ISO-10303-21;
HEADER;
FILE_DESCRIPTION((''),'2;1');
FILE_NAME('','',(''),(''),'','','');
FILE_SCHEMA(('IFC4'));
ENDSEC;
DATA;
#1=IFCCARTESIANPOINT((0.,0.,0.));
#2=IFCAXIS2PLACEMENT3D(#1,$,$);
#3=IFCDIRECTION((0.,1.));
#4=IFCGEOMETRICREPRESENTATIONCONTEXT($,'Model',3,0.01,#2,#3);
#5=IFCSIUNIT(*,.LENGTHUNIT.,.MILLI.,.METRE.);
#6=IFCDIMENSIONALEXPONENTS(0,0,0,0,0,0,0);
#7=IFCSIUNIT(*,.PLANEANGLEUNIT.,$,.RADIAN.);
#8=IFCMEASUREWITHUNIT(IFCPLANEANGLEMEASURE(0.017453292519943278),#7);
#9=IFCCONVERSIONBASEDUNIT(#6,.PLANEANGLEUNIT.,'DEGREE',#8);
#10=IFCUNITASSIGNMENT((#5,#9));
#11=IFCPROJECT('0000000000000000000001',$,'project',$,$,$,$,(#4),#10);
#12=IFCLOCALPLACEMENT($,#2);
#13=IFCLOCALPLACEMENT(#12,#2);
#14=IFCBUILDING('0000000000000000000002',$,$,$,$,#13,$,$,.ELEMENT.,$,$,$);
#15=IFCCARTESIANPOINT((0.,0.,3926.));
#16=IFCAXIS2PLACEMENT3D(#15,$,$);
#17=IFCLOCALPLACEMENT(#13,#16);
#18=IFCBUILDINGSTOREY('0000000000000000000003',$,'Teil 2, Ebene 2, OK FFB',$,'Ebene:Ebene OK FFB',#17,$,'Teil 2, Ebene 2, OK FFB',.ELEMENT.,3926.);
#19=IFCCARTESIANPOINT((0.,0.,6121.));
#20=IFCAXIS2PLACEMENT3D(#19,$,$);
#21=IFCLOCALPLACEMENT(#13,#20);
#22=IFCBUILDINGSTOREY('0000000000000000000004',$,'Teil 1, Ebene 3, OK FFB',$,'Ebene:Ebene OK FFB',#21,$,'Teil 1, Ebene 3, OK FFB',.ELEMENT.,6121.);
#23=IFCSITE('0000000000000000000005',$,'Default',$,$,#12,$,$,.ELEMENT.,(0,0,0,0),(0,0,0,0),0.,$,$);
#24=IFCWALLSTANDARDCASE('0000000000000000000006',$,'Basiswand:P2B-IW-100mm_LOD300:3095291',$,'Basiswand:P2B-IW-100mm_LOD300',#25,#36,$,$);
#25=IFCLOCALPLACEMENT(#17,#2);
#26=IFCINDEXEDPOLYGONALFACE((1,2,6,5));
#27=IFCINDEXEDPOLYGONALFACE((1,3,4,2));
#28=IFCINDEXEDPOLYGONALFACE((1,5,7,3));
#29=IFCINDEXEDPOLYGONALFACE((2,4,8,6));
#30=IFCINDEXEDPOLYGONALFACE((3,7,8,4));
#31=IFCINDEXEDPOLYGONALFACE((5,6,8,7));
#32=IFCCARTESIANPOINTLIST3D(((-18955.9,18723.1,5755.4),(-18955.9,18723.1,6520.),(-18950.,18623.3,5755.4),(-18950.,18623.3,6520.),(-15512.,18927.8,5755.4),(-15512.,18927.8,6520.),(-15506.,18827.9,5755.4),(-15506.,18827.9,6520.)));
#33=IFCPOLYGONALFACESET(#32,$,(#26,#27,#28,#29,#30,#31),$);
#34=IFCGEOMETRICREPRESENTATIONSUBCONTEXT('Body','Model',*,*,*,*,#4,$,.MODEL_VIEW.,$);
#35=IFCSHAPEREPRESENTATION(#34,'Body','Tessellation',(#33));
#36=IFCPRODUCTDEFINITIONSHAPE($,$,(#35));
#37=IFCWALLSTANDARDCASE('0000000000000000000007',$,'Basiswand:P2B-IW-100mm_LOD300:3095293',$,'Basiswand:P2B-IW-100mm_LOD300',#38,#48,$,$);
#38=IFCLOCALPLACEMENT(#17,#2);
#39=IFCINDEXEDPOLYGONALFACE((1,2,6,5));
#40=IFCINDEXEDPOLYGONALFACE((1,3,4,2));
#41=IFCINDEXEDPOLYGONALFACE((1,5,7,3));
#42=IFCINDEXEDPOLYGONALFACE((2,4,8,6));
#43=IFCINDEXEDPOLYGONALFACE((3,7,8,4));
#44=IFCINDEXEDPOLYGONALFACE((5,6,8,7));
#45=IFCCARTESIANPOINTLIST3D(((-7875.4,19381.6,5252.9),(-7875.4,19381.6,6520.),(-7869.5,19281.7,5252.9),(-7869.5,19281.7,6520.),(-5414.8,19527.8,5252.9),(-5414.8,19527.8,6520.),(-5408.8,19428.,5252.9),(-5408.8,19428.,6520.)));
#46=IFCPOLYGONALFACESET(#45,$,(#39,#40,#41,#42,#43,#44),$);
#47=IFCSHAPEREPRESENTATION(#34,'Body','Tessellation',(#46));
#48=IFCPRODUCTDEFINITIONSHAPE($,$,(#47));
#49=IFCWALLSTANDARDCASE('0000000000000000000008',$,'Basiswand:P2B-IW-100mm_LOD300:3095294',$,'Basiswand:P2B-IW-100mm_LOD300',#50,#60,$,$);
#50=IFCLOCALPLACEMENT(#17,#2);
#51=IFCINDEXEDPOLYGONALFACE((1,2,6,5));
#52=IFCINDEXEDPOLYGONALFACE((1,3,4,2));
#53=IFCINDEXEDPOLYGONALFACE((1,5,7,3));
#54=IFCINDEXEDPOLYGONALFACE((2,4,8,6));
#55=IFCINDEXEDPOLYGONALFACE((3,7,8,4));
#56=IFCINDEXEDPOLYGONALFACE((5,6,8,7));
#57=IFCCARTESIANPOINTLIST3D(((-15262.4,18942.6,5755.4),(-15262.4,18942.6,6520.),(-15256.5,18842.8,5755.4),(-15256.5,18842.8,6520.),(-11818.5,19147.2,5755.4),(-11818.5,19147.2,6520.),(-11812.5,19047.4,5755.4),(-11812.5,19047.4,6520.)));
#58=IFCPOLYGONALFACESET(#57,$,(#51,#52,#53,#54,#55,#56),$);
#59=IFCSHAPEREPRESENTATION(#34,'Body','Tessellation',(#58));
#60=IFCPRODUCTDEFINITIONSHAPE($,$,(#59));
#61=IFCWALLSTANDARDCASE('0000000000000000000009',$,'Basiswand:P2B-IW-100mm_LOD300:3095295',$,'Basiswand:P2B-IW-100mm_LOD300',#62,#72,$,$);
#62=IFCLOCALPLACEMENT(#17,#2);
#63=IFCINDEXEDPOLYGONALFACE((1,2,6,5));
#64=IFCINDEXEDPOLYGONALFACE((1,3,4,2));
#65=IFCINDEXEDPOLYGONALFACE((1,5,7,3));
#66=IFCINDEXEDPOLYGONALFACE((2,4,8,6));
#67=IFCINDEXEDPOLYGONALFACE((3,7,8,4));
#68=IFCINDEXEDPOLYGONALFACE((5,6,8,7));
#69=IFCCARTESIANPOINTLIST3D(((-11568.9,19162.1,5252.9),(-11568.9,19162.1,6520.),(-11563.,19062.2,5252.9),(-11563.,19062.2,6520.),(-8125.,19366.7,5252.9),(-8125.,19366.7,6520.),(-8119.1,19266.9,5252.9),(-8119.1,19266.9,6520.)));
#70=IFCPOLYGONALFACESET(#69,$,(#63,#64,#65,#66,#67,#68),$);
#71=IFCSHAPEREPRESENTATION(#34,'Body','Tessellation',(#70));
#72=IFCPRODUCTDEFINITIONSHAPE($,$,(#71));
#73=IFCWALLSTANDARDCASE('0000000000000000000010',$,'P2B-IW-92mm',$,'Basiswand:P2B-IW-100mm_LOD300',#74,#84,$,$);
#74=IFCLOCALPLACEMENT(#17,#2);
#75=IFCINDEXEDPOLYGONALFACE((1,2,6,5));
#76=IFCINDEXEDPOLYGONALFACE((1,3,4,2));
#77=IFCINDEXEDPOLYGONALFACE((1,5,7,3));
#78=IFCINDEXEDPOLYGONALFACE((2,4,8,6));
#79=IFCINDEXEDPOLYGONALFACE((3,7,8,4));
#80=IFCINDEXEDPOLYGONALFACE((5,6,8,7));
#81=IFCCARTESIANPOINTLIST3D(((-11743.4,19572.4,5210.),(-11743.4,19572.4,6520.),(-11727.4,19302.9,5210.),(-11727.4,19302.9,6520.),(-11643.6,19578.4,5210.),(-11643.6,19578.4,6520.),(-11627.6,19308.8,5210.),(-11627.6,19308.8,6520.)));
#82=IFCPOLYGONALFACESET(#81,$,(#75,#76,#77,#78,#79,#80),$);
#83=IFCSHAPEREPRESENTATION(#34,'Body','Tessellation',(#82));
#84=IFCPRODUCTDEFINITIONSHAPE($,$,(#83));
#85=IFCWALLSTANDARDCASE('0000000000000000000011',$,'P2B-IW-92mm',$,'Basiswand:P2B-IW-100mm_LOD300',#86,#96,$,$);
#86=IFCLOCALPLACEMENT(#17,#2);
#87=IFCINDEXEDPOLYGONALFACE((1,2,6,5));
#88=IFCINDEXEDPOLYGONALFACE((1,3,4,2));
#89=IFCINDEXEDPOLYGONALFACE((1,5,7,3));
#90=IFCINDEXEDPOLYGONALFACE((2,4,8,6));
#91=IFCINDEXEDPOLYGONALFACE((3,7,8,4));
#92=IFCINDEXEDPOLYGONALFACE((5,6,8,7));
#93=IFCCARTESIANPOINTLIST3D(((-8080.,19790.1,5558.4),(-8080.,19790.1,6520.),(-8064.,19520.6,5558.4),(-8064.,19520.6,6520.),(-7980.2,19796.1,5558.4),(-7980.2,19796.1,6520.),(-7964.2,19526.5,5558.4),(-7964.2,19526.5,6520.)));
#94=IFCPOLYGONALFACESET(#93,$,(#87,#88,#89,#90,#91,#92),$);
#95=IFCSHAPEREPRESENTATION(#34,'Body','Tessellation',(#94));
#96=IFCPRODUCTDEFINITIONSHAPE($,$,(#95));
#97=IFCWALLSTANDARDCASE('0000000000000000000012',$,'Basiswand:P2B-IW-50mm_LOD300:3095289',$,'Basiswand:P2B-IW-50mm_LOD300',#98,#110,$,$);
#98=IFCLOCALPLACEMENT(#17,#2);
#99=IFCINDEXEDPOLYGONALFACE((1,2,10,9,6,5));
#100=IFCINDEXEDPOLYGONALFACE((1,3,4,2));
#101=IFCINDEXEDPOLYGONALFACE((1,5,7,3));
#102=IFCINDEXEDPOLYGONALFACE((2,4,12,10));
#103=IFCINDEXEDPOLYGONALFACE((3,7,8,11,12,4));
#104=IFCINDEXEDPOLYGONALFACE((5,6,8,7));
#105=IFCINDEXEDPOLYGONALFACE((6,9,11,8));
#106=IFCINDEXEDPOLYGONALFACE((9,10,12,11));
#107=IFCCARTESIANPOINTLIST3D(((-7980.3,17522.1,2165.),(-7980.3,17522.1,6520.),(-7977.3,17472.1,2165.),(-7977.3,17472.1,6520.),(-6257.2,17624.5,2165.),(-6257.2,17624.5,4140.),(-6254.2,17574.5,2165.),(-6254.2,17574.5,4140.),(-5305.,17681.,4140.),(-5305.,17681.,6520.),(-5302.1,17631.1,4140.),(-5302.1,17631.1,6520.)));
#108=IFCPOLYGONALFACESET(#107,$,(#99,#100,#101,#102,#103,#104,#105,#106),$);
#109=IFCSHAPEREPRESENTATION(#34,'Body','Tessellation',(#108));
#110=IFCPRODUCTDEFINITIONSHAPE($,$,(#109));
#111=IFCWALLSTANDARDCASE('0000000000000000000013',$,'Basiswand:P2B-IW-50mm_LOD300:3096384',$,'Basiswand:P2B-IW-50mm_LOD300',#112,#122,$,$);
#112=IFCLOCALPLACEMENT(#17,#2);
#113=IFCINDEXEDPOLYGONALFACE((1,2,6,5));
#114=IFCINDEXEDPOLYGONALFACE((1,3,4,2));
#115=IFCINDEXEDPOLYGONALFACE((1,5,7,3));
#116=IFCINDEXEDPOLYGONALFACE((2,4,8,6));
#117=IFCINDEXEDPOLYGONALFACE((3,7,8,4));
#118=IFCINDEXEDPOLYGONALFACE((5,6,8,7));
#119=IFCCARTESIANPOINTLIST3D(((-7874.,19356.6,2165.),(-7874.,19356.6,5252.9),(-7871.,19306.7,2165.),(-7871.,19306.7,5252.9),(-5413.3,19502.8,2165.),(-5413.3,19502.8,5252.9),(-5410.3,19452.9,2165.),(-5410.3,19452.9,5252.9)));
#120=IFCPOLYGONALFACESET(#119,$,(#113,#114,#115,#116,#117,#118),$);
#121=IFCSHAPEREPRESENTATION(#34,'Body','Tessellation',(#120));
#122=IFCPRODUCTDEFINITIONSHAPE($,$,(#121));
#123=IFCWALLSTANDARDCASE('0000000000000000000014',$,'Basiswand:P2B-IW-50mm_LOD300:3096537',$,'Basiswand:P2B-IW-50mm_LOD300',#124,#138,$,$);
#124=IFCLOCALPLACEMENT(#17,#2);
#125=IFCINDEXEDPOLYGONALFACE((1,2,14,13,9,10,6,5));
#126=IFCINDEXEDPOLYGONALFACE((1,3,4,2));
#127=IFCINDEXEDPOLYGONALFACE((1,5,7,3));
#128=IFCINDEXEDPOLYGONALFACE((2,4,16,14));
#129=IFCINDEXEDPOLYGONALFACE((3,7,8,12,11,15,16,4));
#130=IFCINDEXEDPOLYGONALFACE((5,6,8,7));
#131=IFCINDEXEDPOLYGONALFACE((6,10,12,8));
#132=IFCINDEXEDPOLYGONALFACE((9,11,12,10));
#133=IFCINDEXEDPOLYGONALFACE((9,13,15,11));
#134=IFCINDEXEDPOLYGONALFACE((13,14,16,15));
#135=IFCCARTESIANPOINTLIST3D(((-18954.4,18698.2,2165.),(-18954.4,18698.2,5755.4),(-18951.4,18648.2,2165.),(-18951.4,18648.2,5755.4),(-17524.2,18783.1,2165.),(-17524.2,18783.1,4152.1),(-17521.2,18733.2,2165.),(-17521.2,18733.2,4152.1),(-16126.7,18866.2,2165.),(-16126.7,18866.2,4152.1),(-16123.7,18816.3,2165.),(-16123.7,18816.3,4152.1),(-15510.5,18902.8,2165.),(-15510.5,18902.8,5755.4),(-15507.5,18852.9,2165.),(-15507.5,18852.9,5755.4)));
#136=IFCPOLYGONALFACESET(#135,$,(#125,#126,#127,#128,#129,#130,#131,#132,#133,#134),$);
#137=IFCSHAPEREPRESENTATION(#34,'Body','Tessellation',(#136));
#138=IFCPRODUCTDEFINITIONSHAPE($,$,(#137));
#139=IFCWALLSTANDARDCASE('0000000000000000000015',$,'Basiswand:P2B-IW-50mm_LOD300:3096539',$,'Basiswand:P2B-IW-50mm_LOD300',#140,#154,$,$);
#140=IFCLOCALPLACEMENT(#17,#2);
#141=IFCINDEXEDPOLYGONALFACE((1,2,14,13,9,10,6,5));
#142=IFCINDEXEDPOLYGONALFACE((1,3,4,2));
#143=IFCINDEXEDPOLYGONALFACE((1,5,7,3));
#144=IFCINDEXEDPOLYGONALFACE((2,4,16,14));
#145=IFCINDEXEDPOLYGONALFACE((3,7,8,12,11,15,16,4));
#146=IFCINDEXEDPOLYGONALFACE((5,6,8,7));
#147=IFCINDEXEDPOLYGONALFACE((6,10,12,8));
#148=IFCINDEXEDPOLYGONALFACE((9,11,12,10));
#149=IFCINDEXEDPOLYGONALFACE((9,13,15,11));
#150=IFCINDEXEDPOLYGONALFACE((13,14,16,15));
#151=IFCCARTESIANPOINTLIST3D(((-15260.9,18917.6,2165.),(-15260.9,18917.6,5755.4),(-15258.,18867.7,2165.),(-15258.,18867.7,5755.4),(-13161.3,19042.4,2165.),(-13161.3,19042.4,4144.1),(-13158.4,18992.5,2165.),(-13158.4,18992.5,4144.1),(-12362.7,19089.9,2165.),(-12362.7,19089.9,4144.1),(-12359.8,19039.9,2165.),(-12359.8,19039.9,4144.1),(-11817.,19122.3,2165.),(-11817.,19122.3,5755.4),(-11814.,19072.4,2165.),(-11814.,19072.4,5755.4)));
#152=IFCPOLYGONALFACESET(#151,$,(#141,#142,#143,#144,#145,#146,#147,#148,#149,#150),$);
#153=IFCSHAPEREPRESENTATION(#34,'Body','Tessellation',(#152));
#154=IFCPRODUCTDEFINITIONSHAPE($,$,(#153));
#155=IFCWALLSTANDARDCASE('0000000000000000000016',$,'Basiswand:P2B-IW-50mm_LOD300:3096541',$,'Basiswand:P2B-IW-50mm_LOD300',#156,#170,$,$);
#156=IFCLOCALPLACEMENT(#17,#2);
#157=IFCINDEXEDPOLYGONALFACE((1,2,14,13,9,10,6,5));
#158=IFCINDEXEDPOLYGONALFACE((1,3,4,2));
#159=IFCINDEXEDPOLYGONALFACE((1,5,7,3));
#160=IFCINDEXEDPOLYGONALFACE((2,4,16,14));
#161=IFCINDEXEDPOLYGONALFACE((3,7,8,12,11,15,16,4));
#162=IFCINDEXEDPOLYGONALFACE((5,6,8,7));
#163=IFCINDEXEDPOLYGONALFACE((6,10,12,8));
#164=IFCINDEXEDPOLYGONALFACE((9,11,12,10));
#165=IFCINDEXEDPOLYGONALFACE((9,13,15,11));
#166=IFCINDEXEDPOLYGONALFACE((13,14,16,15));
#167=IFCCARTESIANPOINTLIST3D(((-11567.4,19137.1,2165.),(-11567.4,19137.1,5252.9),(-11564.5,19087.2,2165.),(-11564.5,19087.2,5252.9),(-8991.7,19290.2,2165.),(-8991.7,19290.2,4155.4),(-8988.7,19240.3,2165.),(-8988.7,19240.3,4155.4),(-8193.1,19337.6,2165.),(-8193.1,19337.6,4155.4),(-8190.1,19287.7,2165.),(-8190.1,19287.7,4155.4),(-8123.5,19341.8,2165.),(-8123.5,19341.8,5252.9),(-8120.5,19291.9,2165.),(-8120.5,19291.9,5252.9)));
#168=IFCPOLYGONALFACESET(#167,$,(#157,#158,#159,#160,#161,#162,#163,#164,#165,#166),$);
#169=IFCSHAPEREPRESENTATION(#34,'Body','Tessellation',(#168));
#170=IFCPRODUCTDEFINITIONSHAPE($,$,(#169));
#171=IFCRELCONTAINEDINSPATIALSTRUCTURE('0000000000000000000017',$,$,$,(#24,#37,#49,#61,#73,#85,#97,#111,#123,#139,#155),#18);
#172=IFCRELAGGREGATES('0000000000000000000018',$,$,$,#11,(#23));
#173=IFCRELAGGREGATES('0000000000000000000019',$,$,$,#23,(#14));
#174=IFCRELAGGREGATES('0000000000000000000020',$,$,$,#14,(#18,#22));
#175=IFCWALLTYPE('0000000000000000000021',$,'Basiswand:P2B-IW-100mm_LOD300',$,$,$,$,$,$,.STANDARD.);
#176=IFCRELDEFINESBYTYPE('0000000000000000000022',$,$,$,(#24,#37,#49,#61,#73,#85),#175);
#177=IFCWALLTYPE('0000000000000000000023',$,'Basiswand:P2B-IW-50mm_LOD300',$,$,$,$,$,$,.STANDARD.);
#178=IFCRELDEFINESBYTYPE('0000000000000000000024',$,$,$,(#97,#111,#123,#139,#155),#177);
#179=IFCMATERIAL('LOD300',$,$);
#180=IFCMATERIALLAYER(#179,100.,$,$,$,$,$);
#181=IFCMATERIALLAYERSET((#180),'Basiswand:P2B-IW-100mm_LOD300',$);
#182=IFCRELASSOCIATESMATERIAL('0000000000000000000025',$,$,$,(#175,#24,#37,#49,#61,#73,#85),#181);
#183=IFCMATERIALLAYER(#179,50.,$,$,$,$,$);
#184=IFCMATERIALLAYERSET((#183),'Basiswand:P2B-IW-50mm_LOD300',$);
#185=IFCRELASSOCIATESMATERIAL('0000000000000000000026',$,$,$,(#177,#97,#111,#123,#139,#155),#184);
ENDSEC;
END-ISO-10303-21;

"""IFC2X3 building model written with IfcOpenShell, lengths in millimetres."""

from ifc_helpers import new_model, entity, si_unit, converted_unit, direction, frame, frame_2d, origin, place, context, subcontext, project, spatial, rectangle, extrude, material, layer, layer_set, layer_usage, type_object, element, save


model = new_model("IFC2X3")

# Units and contexts
model_context = context("Model", 3, precision=0.01, world=origin(), true_north=direction((0.0, 1.0)))
body_context = subcontext(model_context, "Body", "Model", "MODEL_VIEW")
ifc_project = project(units=[si_unit("LENGTHUNIT", "METRE", prefix="MILLI"), converted_unit("PLANEANGLEUNIT", "DEGREE", entity("IfcPlaneAngleMeasure", 0.017453292519943278), si_unit("PLANEANGLEUNIT", "RADIAN"), dimensions=[0, 0, 0, 0, 0, 0, 0])], contexts=[model_context])

# Site, building, storey
site_placement = place(None, origin())
site = spatial("IfcSite", under=ifc_project, at=site_placement, Name="Default", CompositionType="ELEMENT", RefLatitude=(0, 0, 0, 0), RefLongitude=(0, 0, 0, 0), RefElevation=0.0)
building_placement = place(site_placement, origin())
building = spatial("IfcBuilding", under=site, at=building_placement, CompositionType="ELEMENT")
storey_1_placement = place(building_placement, frame((0.0, 0.0, 3926.0)))
storey_1 = spatial("IfcBuildingStorey", under=building, at=storey_1_placement, Name="Teil 2, Ebene 2, OK FFB", ObjectType="Ebene:Ebene OK FFB", LongName="Teil 2, Ebene 2, OK FFB", CompositionType="ELEMENT", Elevation=3926.0)

# Shared definitions
storey_2_placement = place(building_placement, frame((0.0, 0.0, 6121.0)))
storey_2 = spatial("IfcBuildingStorey", under=building, at=storey_2_placement, Name="Teil 1, Ebene 3, OK FFB", ObjectType="Ebene:Ebene OK FFB", LongName="Teil 1, Ebene 3, OK FFB", CompositionType="ELEMENT", Elevation=6121.0)

# Walls
ifc_material_1 = material(Name="LOD300")
ifc_layer_1 = layer(ifc_material_1, 100.0)
ifc_layer_set_1 = layer_set([ifc_layer_1], Name="Basiswand:P2B-IW-100mm_LOD300")
ifc_layer_usage_1 = layer_usage(ifc_layer_set_1, "AXIS2", "POSITIVE", -50.0)
wall_type_1 = type_object("IfcWallType", Name="Basiswand:P2B-IW-100mm_LOD300", PredefinedType="STANDARD", material=ifc_layer_set_1)
wall_1_placement = place(storey_1_placement, frame((-15509.0, 18877.8, 5755.4), z_axis=(0.0, 0.0, 1.0), x_axis=(-0.998239, -0.059319, 0.0)))
element("IfcWallStandardCase", 1, at=wall_1_placement, inside=storey_1, type_object=wall_type_1, material=ifc_layer_usage_1, Name="Basiswand:P2B-IW-100mm_LOD300:3095291", ObjectType="Basiswand:P2B-IW-100mm_LOD300", context=body_context, shape_type="SweptSolid", body=[
    extrude(rectangle(XDim=3450.0, YDim=100.0, at=frame_2d((1725.0, 0.0), x_axis=(-1.0, 0.0))), origin(), (0.0, 0.0, 1.0), 764.6),
])
ifc_layer_usage_2 = layer_usage(ifc_layer_set_1, "AXIS2", "POSITIVE", -50.0)
wall_2_placement = place(storey_1_placement, frame((-5411.8, 19477.9, 5252.9), z_axis=(0.0, 0.0, 1.0), x_axis=(-0.998239, -0.059319, 0.0)))
element("IfcWallStandardCase", 2, at=wall_2_placement, inside=storey_1, type_object=wall_type_1, material=ifc_layer_usage_2, Name="Basiswand:P2B-IW-100mm_LOD300:3095293", ObjectType="Basiswand:P2B-IW-100mm_LOD300", context=body_context, shape_type="SweptSolid", body=[
    extrude(rectangle(XDim=2465.0, YDim=100.0, at=frame_2d((1232.5, 0.0), x_axis=(-1.0, 0.0))), origin(), (0.0, 0.0, 1.0), 1267.1),
])
ifc_layer_usage_3 = layer_usage(ifc_layer_set_1, "AXIS2", "POSITIVE", -50.0)
wall_3_placement = place(storey_1_placement, frame((-11815.5, 19097.3, 5755.4), z_axis=(0.0, 0.0, 1.0), x_axis=(-0.998239, -0.059319, 0.0)))
element("IfcWallStandardCase", 3, at=wall_3_placement, inside=storey_1, type_object=wall_type_1, material=ifc_layer_usage_3, Name="Basiswand:P2B-IW-100mm_LOD300:3095294", ObjectType="Basiswand:P2B-IW-100mm_LOD300", context=body_context, shape_type="SweptSolid", body=[
    extrude(rectangle(XDim=3450.0, YDim=100.0, at=frame_2d((1725.0, 0.0), x_axis=(-1.0, 0.0))), origin(), (0.0, 0.0, 1.0), 764.6),
])
ifc_layer_usage_4 = layer_usage(ifc_layer_set_1, "AXIS2", "POSITIVE", -50.0)
wall_4_placement = place(storey_1_placement, frame((-8122.0, 19316.8, 5252.9), z_axis=(0.0, 0.0, 1.0), x_axis=(-0.998239, -0.059319, 0.0)))
element("IfcWallStandardCase", 4, at=wall_4_placement, inside=storey_1, type_object=wall_type_1, material=ifc_layer_usage_4, Name="Basiswand:P2B-IW-100mm_LOD300:3095295", ObjectType="Basiswand:P2B-IW-100mm_LOD300", context=body_context, shape_type="SweptSolid", body=[
    extrude(rectangle(XDim=3450.0, YDim=100.0, at=frame_2d((1725.0, 0.0), x_axis=(-1.0, 0.0))), origin(), (0.0, 0.0, 1.0), 1267.1),
])
ifc_layer_usage_5 = layer_usage(ifc_layer_set_1, "AXIS2", "POSITIVE", -50.0)
wall_5_placement = place(storey_1_placement, frame((-11677.5, 19305.9, 5210.0), z_axis=(0.0, 0.0, 1.0), x_axis=(-0.059319, 0.998239, 0.0)))
element("IfcWallStandardCase", 5, at=wall_5_placement, inside=storey_1, type_object=wall_type_1, material=ifc_layer_usage_5, Name="P2B-IW-92mm", ObjectType="Basiswand:P2B-IW-100mm_LOD300", context=body_context, shape_type="SweptSolid", body=[
    extrude(rectangle(XDim=270.0, YDim=100.0, at=frame_2d((135.0, 0.0), x_axis=(-1.0, 0.0))), origin(), (0.0, 0.0, 1.0), 1310.0),
])
ifc_layer_usage_6 = layer_usage(ifc_layer_set_1, "AXIS2", "POSITIVE", -50.0)
wall_6_placement = place(storey_1_placement, frame((-8014.1, 19523.6, 5558.4), z_axis=(0.0, 0.0, 1.0), x_axis=(-0.059319, 0.998239, 0.0)))
element("IfcWallStandardCase", 6, at=wall_6_placement, inside=storey_1, type_object=wall_type_1, material=ifc_layer_usage_6, Name="P2B-IW-92mm", ObjectType="Basiswand:P2B-IW-100mm_LOD300", context=body_context, shape_type="SweptSolid", body=[
    extrude(rectangle(XDim=270.0, YDim=100.0, at=frame_2d((135.0, 0.0), x_axis=(-1.0, 0.0))), origin(), (0.0, 0.0, 1.0), 961.6),
])

# Wall, opening
ifc_layer_2 = layer(ifc_material_1, 50.0)
ifc_layer_set_2 = layer_set([ifc_layer_2], Name="Basiswand:P2B-IW-50mm_LOD300")
ifc_layer_usage_7 = layer_usage(ifc_layer_set_2, "AXIS2", "NEGATIVE", 25.0)
wall_type_2 = type_object("IfcWallType", Name="Basiswand:P2B-IW-50mm_LOD300", PredefinedType="STANDARD", material=ifc_layer_set_2)
wall_7_placement = place(storey_1_placement, frame((-5303.6, 17656.1, 2165.0), z_axis=(0.0, 0.0, 1.0), x_axis=(-0.998239, -0.059319, 0.0)))
wall_7 = element("IfcWallStandardCase", 7, at=wall_7_placement, inside=storey_1, type_object=wall_type_2, material=ifc_layer_usage_7, Name="Basiswand:P2B-IW-50mm_LOD300:3095289", ObjectType="Basiswand:P2B-IW-50mm_LOD300", context=body_context, shape_type="SweptSolid", body=[
    extrude(rectangle(XDim=2680.0, YDim=50.0, at=frame_2d((1340.0, 0.0), x_axis=(-1.0, 0.0))), origin(), (0.0, 0.0, 1.0), 4355.0),
])
opening_1_placement = place(wall_7_placement, origin())
element("IfcOpeningElement", 8, at=opening_1_placement, cuts=wall_7, ObjectType="Opening", context=body_context, shape_type="SweptSolid", body=[
    extrude(rectangle(XDim=1975.0, YDim=953.8, at=frame_2d((0.0, 0.0), x_axis=(1.0, 0.0))), frame((476.9, -25.0, 987.5), z_axis=(0.0, 1.0, 0.0), x_axis=(0.0, 0.0, -1.0)), (0.0, 0.0, 1.0), 50.0),
])

# Wall
ifc_layer_usage_8 = layer_usage(ifc_layer_set_2, "AXIS2", "POSITIVE", -25.0)
wall_8_placement = place(storey_1_placement, frame((-5411.8, 19477.9, 2165.0), z_axis=(0.0, 0.0, 1.0), x_axis=(-0.998239, -0.059319, 0.0)))
element("IfcWallStandardCase", 9, at=wall_8_placement, inside=storey_1, type_object=wall_type_2, material=ifc_layer_usage_8, Name="Basiswand:P2B-IW-50mm_LOD300:3096384", ObjectType="Basiswand:P2B-IW-50mm_LOD300", context=body_context, shape_type="SweptSolid", body=[
    extrude(rectangle(XDim=2465.0, YDim=50.0, at=frame_2d((1232.5, 0.0), x_axis=(-1.0, 0.0))), origin(), (0.0, 0.0, 1.0), 3087.9),
])

# Walls, openings
ifc_layer_usage_9 = layer_usage(ifc_layer_set_2, "AXIS2", "POSITIVE", -25.0)
wall_9_placement = place(storey_1_placement, frame((-15509.0, 18877.8, 2165.0), z_axis=(0.0, 0.0, 1.0), x_axis=(-0.998239, -0.059319, 0.0)))
wall_9 = element("IfcWallStandardCase", 10, at=wall_9_placement, inside=storey_1, type_object=wall_type_2, material=ifc_layer_usage_9, Name="Basiswand:P2B-IW-50mm_LOD300:3096537", ObjectType="Basiswand:P2B-IW-50mm_LOD300", context=body_context, shape_type="SweptSolid", body=[
    extrude(rectangle(XDim=3450.0, YDim=50.0, at=frame_2d((1725.0, 0.0), x_axis=(-1.0, 0.0))), origin(), (0.0, 0.0, 1.0), 3590.4),
])
opening_2_placement = place(wall_9_placement, origin())
element("IfcOpeningElement", 11, at=opening_2_placement, cuts=wall_9, ObjectType="Opening", context=body_context, shape_type="SweptSolid", body=[
    extrude(rectangle(XDim=1987.1, YDim=1400.0, at=frame_2d((0.0, 0.0), x_axis=(1.0, 0.0))), frame((1317.3, -25.0, 993.5), z_axis=(0.0, 1.0, 0.0), x_axis=(0.0, 0.0, -1.0)), (0.0, 0.0, 1.0), 50.0),
])
ifc_layer_usage_10 = layer_usage(ifc_layer_set_2, "AXIS2", "POSITIVE", -25.0)
wall_10_placement = place(storey_1_placement, frame((-11815.5, 19097.3, 2165.0), z_axis=(0.0, 0.0, 1.0), x_axis=(-0.998239, -0.059319, 0.0)))
wall_10 = element("IfcWallStandardCase", 12, at=wall_10_placement, inside=storey_1, type_object=wall_type_2, material=ifc_layer_usage_10, Name="Basiswand:P2B-IW-50mm_LOD300:3096539", ObjectType="Basiswand:P2B-IW-50mm_LOD300", context=body_context, shape_type="SweptSolid", body=[
    extrude(rectangle(XDim=3450.0, YDim=50.0, at=frame_2d((1725.0, 0.0), x_axis=(-1.0, 0.0))), origin(), (0.0, 0.0, 1.0), 3590.4),
])
opening_3_placement = place(wall_10_placement, origin())
element("IfcOpeningElement", 13, at=opening_3_placement, cuts=wall_10, ObjectType="Opening", context=body_context, shape_type="SweptSolid", body=[
    extrude(rectangle(XDim=1979.1, YDim=800.0, at=frame_2d((0.0, 0.0), x_axis=(1.0, 0.0))), frame((946.7, -25.0, 989.6), z_axis=(0.0, 1.0, 0.0), x_axis=(0.0, 0.0, -1.0)), (0.0, 0.0, 1.0), 50.0),
])
ifc_layer_usage_11 = layer_usage(ifc_layer_set_2, "AXIS2", "POSITIVE", -25.0)
wall_11_placement = place(storey_1_placement, frame((-8122.0, 19316.8, 2165.0), z_axis=(0.0, 0.0, 1.0), x_axis=(-0.998239, -0.059319, 0.0)))
wall_11 = element("IfcWallStandardCase", 14, at=wall_11_placement, inside=storey_1, type_object=wall_type_2, material=ifc_layer_usage_11, Name="Basiswand:P2B-IW-50mm_LOD300:3096541", ObjectType="Basiswand:P2B-IW-50mm_LOD300", context=body_context, shape_type="SweptSolid", body=[
    extrude(rectangle(XDim=3450.0, YDim=50.0, at=frame_2d((1725.0, 0.0), x_axis=(-1.0, 0.0))), origin(), (0.0, 0.0, 1.0), 3087.9),
])
opening_4_placement = place(wall_11_placement, origin())
element("IfcOpeningElement", 15, at=opening_4_placement, cuts=wall_11, ObjectType="Opening", context=body_context, shape_type="SweptSolid", body=[
    extrude(rectangle(XDim=1990.4, YDim=800.0, at=frame_2d((0.0, 0.0), x_axis=(1.0, 0.0))), frame((469.7, -25.0, 995.2), z_axis=(0.0, 1.0, 0.0), x_axis=(0.0, 0.0, -1.0)), (0.0, 0.0, 1.0), 50.0),
])

save(model, "model.ifc")
